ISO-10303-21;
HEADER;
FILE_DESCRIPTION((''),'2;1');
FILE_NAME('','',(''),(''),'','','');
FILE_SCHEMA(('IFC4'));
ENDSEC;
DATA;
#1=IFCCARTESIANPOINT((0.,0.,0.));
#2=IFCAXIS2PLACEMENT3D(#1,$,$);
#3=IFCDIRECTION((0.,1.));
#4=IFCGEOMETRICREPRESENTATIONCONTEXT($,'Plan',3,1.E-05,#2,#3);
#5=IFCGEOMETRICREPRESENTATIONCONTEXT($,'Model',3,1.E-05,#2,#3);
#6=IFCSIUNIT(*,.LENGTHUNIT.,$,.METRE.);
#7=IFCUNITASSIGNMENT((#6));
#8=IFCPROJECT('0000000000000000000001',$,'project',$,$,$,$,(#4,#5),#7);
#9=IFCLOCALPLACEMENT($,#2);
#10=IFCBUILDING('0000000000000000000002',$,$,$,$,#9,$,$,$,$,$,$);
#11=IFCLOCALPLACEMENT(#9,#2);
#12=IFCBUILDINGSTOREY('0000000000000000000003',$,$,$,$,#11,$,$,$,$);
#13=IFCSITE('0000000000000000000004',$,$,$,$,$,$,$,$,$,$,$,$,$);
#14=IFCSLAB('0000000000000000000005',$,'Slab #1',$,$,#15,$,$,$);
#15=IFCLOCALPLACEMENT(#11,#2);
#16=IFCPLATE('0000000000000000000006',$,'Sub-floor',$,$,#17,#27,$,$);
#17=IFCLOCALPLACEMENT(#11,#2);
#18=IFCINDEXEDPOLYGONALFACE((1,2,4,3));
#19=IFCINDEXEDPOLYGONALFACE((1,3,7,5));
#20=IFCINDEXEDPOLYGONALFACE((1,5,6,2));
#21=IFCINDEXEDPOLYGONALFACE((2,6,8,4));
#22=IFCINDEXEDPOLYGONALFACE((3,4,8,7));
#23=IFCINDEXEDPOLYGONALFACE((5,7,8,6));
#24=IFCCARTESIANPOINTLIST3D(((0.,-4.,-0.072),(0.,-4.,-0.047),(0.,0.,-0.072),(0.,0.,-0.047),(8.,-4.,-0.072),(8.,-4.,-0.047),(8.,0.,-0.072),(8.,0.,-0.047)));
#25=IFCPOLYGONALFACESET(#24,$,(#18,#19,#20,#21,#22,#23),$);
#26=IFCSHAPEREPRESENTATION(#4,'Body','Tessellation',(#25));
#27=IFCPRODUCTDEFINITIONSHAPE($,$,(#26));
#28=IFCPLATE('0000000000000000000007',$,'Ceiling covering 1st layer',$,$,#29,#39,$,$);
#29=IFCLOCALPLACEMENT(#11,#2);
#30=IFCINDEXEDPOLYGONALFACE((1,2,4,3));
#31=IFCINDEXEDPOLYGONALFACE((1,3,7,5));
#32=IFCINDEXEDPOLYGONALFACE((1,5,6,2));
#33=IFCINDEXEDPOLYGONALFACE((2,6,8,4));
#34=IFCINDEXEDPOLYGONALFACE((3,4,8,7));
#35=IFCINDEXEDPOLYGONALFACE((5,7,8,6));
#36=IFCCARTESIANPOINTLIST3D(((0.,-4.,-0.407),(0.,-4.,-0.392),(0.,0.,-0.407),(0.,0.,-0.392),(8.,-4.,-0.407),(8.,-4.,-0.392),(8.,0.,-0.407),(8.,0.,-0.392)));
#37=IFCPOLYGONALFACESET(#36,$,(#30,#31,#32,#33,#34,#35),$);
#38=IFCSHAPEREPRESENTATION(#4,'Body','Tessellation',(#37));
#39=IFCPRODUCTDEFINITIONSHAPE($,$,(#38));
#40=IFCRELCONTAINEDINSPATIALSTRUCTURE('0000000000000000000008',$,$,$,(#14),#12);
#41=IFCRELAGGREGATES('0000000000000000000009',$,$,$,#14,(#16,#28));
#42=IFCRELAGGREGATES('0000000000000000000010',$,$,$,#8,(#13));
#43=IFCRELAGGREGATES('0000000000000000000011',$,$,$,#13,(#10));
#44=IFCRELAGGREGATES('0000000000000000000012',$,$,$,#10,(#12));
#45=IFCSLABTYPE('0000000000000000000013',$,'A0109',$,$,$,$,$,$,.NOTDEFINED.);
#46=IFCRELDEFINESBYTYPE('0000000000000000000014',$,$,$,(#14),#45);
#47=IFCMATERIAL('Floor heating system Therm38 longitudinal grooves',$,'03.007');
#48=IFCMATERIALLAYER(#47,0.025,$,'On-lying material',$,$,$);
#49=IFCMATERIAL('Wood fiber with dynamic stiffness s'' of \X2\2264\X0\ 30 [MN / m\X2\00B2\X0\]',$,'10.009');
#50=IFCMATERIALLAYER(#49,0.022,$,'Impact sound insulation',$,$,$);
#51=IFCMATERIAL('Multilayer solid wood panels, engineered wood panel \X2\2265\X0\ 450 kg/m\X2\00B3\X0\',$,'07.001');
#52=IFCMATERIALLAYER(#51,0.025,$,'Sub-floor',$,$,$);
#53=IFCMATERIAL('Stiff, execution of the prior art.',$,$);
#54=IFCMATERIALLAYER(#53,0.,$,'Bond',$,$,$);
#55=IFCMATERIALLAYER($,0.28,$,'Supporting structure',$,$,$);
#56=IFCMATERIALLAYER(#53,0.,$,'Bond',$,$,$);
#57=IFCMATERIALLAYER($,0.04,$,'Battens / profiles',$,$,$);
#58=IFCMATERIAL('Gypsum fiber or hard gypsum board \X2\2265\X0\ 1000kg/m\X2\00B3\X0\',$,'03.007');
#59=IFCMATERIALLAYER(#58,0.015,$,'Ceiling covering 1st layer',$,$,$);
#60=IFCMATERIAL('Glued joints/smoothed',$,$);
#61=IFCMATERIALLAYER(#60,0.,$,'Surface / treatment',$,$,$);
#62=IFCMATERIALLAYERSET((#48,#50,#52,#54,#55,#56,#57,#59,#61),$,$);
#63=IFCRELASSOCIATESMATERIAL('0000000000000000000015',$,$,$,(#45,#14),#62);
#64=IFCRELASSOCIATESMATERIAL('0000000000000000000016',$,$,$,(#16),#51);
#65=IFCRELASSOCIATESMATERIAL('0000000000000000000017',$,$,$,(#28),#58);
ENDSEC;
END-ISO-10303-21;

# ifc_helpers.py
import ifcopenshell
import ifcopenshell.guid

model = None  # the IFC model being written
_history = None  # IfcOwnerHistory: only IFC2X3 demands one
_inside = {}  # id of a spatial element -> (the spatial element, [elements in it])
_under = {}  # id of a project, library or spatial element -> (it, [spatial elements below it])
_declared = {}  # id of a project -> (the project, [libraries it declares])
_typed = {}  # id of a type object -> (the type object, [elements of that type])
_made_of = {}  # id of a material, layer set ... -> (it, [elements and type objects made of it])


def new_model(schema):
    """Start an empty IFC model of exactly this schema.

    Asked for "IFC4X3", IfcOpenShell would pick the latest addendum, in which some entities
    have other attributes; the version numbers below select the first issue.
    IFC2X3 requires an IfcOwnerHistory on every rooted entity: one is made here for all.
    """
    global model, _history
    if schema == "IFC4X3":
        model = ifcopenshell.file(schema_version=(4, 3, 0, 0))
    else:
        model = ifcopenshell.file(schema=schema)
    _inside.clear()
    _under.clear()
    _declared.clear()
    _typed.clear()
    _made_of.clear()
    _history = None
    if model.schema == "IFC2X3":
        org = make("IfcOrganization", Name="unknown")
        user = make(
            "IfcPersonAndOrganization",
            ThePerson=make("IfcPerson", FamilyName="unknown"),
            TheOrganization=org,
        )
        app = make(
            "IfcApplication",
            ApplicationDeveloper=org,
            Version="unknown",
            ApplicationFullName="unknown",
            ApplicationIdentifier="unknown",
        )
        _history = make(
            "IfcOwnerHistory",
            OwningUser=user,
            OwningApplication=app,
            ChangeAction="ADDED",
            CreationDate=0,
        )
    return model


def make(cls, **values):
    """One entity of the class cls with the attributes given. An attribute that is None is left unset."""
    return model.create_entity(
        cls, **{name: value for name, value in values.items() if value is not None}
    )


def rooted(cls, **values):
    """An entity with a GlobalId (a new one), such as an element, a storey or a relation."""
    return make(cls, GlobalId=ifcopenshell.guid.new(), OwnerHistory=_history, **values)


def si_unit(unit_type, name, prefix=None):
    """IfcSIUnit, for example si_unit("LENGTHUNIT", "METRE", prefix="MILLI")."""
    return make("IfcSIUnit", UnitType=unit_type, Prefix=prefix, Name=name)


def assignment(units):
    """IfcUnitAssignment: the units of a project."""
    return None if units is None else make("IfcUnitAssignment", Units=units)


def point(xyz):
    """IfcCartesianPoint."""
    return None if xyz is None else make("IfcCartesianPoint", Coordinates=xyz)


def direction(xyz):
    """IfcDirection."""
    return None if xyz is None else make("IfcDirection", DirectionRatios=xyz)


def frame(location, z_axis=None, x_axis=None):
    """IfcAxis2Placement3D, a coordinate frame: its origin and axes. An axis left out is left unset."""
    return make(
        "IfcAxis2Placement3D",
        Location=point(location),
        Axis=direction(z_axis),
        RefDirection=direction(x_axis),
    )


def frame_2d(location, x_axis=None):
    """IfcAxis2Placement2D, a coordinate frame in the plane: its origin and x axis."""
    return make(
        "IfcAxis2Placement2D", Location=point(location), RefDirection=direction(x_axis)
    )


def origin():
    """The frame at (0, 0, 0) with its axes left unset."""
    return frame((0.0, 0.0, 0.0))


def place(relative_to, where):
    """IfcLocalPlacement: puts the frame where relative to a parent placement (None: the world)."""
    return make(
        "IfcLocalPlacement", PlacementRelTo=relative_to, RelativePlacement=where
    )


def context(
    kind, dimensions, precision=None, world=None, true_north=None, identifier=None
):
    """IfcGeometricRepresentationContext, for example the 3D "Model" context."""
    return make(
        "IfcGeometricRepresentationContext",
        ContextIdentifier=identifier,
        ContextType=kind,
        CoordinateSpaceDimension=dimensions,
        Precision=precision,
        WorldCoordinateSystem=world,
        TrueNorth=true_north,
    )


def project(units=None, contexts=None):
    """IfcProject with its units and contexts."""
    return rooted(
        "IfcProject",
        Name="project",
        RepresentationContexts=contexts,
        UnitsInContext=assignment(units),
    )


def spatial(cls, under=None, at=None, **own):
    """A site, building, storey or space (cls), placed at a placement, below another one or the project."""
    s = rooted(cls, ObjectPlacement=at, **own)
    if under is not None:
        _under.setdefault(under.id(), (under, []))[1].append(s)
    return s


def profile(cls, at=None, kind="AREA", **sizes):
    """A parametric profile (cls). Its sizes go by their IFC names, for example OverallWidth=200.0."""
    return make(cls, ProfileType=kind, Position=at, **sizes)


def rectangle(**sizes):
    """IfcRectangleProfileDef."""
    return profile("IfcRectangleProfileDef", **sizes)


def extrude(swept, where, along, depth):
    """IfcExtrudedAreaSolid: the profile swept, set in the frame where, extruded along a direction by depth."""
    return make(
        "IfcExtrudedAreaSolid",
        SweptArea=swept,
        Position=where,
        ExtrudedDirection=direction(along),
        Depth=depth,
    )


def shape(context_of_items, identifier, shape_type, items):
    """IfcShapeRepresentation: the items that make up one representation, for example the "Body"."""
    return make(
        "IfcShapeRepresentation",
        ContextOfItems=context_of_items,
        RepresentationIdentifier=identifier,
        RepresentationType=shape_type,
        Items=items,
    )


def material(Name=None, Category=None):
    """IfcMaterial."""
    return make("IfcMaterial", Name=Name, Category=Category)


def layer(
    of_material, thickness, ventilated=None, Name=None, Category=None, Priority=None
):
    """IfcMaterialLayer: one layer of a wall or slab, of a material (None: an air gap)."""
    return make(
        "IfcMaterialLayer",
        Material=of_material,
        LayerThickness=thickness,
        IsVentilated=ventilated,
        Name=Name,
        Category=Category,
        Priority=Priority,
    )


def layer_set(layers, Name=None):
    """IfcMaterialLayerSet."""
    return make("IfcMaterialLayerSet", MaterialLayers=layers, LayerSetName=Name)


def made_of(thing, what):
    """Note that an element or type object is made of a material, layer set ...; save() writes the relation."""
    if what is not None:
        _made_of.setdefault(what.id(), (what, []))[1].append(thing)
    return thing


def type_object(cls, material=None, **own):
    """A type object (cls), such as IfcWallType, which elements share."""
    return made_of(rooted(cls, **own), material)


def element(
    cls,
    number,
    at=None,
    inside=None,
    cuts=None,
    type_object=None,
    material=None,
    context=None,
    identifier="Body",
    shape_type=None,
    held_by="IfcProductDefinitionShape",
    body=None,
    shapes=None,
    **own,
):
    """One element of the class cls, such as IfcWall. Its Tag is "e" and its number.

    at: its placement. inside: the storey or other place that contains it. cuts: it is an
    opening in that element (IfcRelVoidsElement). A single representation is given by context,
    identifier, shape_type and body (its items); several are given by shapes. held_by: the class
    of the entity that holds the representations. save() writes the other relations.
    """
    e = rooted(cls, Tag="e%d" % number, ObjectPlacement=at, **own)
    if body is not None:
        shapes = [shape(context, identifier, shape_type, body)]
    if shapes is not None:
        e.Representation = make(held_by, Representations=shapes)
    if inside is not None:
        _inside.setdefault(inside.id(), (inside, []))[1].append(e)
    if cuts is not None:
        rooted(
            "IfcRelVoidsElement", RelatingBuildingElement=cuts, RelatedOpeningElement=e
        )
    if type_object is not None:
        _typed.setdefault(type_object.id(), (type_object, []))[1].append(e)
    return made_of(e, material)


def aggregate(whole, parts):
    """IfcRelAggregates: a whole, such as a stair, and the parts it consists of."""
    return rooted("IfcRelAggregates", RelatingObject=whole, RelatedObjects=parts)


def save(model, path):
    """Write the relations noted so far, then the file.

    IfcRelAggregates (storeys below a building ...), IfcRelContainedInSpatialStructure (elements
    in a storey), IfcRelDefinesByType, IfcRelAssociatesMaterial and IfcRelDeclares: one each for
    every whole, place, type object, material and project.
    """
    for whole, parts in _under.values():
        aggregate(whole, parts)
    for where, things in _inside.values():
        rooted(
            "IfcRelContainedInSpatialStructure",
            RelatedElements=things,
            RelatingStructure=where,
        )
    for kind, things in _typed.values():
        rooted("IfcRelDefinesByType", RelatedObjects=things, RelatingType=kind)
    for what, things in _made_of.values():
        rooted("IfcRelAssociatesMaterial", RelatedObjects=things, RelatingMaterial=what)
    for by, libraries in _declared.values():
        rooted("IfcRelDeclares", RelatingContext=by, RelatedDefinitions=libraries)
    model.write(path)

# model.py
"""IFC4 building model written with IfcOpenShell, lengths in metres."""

from ifc_helpers import new_model, si_unit, direction, frame, frame_2d, origin, place, context, project, spatial, rectangle, extrude, material, layer, layer_set, type_object, element, aggregate, save


model = new_model("IFC4")

# Units and contexts
plan_context = context("Plan", 3, precision=1e-05, world=origin(), true_north=direction((0.0, 1.0)))
model_context = context("Model", 3, precision=1e-05, world=origin(), true_north=direction((0.0, 1.0)))
ifc_project = project(units=[si_unit("LENGTHUNIT", "METRE")], contexts=[plan_context, model_context])

# Site, building, storey
site = spatial("IfcSite", under=ifc_project)
building_placement = place(None, origin())
building = spatial("IfcBuilding", under=site, at=building_placement)
storey_placement = place(building_placement, origin())
storey = spatial("IfcBuildingStorey", under=building, at=storey_placement)

# Slab, plates
ifc_material_1 = material(Name="Floor heating system Therm38 longitudinal grooves", Category="03.007")
ifc_layer_1 = layer(ifc_material_1, 0.025, Name="On-lying material")
ifc_material_2 = material(Name="Wood fiber with dynamic stiffness s' of ≤ 30 [MN / m²]", Category="10.009")
ifc_layer_2 = layer(ifc_material_2, 0.022, Name="Impact sound insulation")
ifc_material_3 = material(Name="Multilayer solid wood panels, engineered wood panel ≥ 450 kg/m³", Category="07.001")
ifc_layer_3 = layer(ifc_material_3, 0.025, Name="Sub-floor")
ifc_material_4 = material(Name="Stiff, execution of the prior art.")
ifc_layer_4 = layer(ifc_material_4, 0.0, Name="Bond")
ifc_layer_5 = layer(None, 0.28, Name="Supporting structure")
ifc_layer_6 = layer(ifc_material_4, 0.0, Name="Bond")
ifc_layer_7 = layer(None, 0.04, Name="Battens / profiles")
ifc_material_5 = material(Name="Gypsum fiber or hard gypsum board ≥ 1000kg/m³", Category="03.007")
ifc_layer_8 = layer(ifc_material_5, 0.015, Name="Ceiling covering 1st layer")
ifc_material_6 = material(Name="Glued joints/smoothed")
ifc_layer_9 = layer(ifc_material_6, 0.0, Name="Surface / treatment")
ifc_layer_set = layer_set([ifc_layer_1, ifc_layer_2, ifc_layer_3, ifc_layer_4, ifc_layer_5, ifc_layer_6, ifc_layer_7, ifc_layer_8, ifc_layer_9])
slab_type = type_object("IfcSlabType", Name="A0109", PredefinedType="NOTDEFINED", material=ifc_layer_set)
slab_placement = place(None, frame((0.0, 0.0, 0.0), z_axis=(0.0, 0.0, -1.0), x_axis=(1.0, 0.0, 0.0)))
slab = element("IfcSlab", 1, at=slab_placement, inside=storey, type_object=slab_type, material=ifc_layer_set, Name="Slab #1")
plate_1_placement = place(slab_placement, origin())
plate_1 = element("IfcPlate", 2, at=plate_1_placement, material=ifc_material_3, Name="Sub-floor", context=plan_context, shape_type="SweptSolid", body=[
    extrude(rectangle(XDim=8.0, YDim=4.0, at=frame_2d((4.0, 2.0), x_axis=(1.0, 0.0))), frame((0.0, 0.0, 0.047), z_axis=(0.0, 0.0, 1.0), x_axis=(1.0, 0.0, 0.0)), (0.0, 0.0, 1.0), 0.025),
])
plate_2_placement = place(slab_placement, origin())
plate_2 = element("IfcPlate", 3, at=plate_2_placement, material=ifc_material_5, Name="Ceiling covering 1st layer", context=plan_context, shape_type="SweptSolid", body=[
    extrude(rectangle(XDim=8.0, YDim=4.0, at=frame_2d((4.0, 2.0), x_axis=(1.0, 0.0))), frame((0.0, 0.0, 0.392), z_axis=(0.0, 0.0, 1.0), x_axis=(1.0, 0.0, 0.0)), (0.0, 0.0, 1.0), 0.015),
])
aggregate(slab, [plate_1, plate_2])

save(model, "model.ifc")
